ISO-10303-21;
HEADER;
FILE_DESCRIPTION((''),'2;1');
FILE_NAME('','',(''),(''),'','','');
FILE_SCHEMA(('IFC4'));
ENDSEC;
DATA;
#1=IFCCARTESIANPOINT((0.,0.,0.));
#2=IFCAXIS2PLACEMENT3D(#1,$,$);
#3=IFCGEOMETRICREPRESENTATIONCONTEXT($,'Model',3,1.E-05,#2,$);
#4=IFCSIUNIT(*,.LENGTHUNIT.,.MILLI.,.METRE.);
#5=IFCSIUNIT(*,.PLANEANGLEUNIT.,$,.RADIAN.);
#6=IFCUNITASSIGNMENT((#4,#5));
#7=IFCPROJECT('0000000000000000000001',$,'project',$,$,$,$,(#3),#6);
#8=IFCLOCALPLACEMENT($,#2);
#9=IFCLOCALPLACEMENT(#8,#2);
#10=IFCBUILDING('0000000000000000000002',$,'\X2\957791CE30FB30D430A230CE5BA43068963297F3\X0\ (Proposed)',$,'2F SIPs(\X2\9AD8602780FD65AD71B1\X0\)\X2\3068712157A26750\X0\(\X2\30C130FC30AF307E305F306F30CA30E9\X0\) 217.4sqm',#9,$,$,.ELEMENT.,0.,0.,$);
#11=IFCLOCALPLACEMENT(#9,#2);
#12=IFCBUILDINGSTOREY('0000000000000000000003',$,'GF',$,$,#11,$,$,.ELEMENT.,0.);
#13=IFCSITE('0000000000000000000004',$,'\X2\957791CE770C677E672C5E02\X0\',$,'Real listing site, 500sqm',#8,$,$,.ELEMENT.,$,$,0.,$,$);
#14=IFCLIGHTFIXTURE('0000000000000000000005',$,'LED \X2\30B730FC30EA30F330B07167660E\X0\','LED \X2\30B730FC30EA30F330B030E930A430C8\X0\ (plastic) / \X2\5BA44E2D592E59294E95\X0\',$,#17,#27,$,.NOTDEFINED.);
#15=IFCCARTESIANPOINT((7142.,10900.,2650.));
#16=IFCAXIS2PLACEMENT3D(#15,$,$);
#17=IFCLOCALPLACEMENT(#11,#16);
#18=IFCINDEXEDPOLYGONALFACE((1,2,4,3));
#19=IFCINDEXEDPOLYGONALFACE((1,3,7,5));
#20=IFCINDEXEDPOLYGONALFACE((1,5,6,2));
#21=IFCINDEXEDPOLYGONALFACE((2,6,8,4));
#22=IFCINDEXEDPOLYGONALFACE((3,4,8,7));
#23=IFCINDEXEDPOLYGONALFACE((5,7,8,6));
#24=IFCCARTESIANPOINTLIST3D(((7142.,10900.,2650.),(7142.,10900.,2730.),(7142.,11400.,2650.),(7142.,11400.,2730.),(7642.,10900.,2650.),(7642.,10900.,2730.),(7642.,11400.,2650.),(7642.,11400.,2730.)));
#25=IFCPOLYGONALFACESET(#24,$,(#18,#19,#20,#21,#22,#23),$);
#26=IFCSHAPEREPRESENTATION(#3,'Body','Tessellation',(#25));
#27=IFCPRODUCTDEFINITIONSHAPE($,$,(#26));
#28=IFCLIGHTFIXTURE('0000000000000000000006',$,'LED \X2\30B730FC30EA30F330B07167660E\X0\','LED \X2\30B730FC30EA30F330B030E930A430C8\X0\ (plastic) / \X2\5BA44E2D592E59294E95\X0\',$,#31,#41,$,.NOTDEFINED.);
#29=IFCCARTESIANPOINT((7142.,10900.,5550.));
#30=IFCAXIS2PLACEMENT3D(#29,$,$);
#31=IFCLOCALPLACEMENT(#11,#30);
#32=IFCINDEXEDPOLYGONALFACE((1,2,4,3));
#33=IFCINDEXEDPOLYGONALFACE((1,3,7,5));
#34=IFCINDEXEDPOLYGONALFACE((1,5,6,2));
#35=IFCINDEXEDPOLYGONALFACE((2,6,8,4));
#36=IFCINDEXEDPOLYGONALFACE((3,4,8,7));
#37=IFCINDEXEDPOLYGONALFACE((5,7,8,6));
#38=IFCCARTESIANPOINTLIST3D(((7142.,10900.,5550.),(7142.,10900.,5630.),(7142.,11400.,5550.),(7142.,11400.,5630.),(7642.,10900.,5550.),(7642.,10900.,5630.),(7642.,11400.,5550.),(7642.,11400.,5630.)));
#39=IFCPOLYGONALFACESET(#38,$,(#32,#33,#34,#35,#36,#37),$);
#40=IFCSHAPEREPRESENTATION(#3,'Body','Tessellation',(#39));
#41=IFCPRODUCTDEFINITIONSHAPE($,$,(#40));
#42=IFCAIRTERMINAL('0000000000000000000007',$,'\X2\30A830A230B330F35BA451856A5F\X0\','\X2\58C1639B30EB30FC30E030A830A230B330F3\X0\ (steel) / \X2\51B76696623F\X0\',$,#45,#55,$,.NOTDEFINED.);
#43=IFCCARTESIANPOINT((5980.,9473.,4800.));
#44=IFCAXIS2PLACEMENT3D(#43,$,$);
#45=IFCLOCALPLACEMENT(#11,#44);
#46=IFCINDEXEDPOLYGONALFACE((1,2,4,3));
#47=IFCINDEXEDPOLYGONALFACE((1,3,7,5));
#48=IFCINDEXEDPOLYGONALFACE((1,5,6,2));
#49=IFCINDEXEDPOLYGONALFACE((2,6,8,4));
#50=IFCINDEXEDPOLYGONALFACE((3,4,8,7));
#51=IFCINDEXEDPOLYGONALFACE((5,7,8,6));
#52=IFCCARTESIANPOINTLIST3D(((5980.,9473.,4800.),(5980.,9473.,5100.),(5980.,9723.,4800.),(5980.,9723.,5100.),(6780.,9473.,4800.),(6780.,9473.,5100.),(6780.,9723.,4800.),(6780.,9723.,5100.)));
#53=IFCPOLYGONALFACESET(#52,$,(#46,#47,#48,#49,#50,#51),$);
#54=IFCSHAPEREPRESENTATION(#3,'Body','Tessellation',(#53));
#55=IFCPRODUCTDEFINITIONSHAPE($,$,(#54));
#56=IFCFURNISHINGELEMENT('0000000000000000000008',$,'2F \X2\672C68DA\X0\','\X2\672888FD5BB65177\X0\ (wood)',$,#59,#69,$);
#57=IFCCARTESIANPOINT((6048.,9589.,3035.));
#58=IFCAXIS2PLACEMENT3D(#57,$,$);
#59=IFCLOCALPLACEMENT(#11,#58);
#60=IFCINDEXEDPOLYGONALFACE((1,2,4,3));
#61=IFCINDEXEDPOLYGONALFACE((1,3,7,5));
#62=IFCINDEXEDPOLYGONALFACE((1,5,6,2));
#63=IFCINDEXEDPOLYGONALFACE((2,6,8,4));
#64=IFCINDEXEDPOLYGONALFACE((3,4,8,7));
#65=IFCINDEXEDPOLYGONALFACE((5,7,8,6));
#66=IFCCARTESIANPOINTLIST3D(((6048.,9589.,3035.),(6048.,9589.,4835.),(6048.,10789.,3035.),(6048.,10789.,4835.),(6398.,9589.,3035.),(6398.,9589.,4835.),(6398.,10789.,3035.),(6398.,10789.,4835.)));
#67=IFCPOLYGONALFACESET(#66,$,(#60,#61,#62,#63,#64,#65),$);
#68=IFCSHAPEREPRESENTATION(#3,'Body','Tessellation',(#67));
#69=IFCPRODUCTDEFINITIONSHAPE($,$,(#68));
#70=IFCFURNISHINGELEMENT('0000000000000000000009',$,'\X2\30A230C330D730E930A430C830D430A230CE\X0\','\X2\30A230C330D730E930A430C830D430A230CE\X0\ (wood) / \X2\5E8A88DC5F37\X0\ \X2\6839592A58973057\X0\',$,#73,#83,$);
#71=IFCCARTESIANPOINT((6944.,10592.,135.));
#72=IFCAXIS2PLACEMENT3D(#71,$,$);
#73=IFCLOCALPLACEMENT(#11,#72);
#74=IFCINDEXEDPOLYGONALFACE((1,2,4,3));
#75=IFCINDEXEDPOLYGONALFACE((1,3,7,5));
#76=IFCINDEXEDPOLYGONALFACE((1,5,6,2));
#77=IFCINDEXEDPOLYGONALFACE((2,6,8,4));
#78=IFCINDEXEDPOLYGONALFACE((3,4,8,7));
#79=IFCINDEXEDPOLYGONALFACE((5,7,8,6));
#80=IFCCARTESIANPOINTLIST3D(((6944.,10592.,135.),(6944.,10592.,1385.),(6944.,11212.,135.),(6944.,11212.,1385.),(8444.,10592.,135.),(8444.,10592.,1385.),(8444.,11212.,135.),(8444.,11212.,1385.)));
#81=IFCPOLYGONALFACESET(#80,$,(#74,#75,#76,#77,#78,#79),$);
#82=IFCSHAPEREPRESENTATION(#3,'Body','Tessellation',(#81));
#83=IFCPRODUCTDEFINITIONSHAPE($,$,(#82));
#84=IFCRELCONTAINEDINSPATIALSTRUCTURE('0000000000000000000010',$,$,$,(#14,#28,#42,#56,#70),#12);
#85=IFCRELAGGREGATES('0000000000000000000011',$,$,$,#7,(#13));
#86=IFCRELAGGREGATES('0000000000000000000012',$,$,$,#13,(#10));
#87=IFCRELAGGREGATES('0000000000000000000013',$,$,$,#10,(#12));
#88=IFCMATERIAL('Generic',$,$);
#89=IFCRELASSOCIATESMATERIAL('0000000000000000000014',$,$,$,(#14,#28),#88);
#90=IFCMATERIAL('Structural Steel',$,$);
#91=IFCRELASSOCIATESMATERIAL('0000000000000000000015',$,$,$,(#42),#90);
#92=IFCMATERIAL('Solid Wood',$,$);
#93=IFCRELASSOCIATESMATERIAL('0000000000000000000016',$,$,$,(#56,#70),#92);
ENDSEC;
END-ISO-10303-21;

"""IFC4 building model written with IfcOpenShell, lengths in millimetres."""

from ifc_helpers import new_model, si_unit, frame, frame_2d, origin, place, context, project, spatial, rectangle, extrude, material, element, save


model = new_model("IFC4")

# Units and contexts
model_context = context("Model", 3, precision=1e-05, world=origin())
ifc_project = project(units=[si_unit("LENGTHUNIT", "METRE", prefix="MILLI"), si_unit("PLANEANGLEUNIT", "RADIAN")], contexts=[model_context])

# Site, building, storey
site_placement = place(None, origin())
site = spatial("IfcSite", under=ifc_project, at=site_placement, Name="長野県松本市", ObjectType="Real listing site, 500sqm", CompositionType="ELEMENT", RefElevation=0.0)
building_placement = place(site_placement, origin())
building = spatial("IfcBuilding", under=site, at=building_placement, Name="長野・ピアノ室と防音 (Proposed)", ObjectType="2F SIPs(高性能断熱)と無垢材(チークまたはナラ) 217.4sqm", CompositionType="ELEMENT", ElevationOfRefHeight=0.0, ElevationOfTerrain=0.0)
storey_placement = place(building_placement, origin())
storey = spatial("IfcBuildingStorey", under=building, at=storey_placement, Name="GF", CompositionType="ELEMENT", Elevation=0.0)

# Shared definitions
ifc_material_1 = material(Name="Solid Wood")

# Shared definitions
ifc_material_2 = material(Name="Structural Steel")

# Shared definitions
ifc_material_3 = material(Name="Generic")

# Light fixtures
light_fixture_1_placement = place(storey_placement, frame((7142.0, 10900.0, 2650.0)))
element("IfcLightFixture", 1, at=light_fixture_1_placement, inside=storey, material=ifc_material_3, Name="LED シーリング照明", Description="LED シーリングライト (plastic) / 室中央天井", PredefinedType="NOTDEFINED", context=model_context, shape_type="SweptSolid", body=[
    extrude(rectangle(XDim=500.0, YDim=500.0, at=frame_2d((250.0, 250.0))), frame((7142.0, 10900.0, 2650.0)), (0.0, 0.0, 1.0), 80.0),
])
light_fixture_2_placement = place(storey_placement, frame((7142.0, 10900.0, 5550.0)))
element("IfcLightFixture", 2, at=light_fixture_2_placement, inside=storey, material=ifc_material_3, Name="LED シーリング照明", Description="LED シーリングライト (plastic) / 室中央天井", PredefinedType="NOTDEFINED", context=model_context, shape_type="SweptSolid", body=[
    extrude(rectangle(XDim=500.0, YDim=500.0, at=frame_2d((250.0, 250.0))), frame((7142.0, 10900.0, 5550.0)), (0.0, 0.0, 1.0), 80.0),
])

# Air terminal
air_terminal_placement = place(storey_placement, frame((5980.0, 9473.0, 4800.0)))
element("IfcAirTerminal", 3, at=air_terminal_placement, inside=storey, material=ifc_material_2, Name="エアコン室内機", Description="壁掛ルームエアコン (steel) / 冷暖房", PredefinedType="NOTDEFINED", context=model_context, shape_type="SweptSolid", body=[
    extrude(rectangle(XDim=800.0, YDim=250.0, at=frame_2d((400.0, 125.0))), frame((5980.0, 9473.0, 4800.0)), (0.0, 0.0, 1.0), 300.0),
])

# Furnishing elements
furnishing_1_placement = place(storey_placement, frame((6048.0, 9589.0, 3035.0)))
element("IfcFurnishingElement", 4, at=furnishing_1_placement, inside=storey, material=ifc_material_1, Name="2F 本棚", Description="木製家具 (wood)", context=model_context, shape_type="SweptSolid", body=[
    extrude(rectangle(XDim=350.0, YDim=1200.0, at=frame_2d((175.0, 600.0))), frame((6048.0, 9589.0, 3035.0)), (0.0, 0.0, 1.0), 1800.0),
])
furnishing_2_placement = place(storey_placement, frame((6944.0, 10592.0, 135.0)))
element("IfcFurnishingElement", 5, at=furnishing_2_placement, inside=storey, material=ifc_material_1, Name="アップライトピアノ", Description="アップライトピアノ (wood) / 床補強 根太増し", context=model_context, shape_type="SweptSolid", body=[
    extrude(rectangle(XDim=1500.0, YDim=620.0, at=frame_2d((750.0, 310.0))), frame((6944.0, 10592.0, 135.0)), (0.0, 0.0, 1.0), 1250.0),
])

save(model, "model.ifc")
